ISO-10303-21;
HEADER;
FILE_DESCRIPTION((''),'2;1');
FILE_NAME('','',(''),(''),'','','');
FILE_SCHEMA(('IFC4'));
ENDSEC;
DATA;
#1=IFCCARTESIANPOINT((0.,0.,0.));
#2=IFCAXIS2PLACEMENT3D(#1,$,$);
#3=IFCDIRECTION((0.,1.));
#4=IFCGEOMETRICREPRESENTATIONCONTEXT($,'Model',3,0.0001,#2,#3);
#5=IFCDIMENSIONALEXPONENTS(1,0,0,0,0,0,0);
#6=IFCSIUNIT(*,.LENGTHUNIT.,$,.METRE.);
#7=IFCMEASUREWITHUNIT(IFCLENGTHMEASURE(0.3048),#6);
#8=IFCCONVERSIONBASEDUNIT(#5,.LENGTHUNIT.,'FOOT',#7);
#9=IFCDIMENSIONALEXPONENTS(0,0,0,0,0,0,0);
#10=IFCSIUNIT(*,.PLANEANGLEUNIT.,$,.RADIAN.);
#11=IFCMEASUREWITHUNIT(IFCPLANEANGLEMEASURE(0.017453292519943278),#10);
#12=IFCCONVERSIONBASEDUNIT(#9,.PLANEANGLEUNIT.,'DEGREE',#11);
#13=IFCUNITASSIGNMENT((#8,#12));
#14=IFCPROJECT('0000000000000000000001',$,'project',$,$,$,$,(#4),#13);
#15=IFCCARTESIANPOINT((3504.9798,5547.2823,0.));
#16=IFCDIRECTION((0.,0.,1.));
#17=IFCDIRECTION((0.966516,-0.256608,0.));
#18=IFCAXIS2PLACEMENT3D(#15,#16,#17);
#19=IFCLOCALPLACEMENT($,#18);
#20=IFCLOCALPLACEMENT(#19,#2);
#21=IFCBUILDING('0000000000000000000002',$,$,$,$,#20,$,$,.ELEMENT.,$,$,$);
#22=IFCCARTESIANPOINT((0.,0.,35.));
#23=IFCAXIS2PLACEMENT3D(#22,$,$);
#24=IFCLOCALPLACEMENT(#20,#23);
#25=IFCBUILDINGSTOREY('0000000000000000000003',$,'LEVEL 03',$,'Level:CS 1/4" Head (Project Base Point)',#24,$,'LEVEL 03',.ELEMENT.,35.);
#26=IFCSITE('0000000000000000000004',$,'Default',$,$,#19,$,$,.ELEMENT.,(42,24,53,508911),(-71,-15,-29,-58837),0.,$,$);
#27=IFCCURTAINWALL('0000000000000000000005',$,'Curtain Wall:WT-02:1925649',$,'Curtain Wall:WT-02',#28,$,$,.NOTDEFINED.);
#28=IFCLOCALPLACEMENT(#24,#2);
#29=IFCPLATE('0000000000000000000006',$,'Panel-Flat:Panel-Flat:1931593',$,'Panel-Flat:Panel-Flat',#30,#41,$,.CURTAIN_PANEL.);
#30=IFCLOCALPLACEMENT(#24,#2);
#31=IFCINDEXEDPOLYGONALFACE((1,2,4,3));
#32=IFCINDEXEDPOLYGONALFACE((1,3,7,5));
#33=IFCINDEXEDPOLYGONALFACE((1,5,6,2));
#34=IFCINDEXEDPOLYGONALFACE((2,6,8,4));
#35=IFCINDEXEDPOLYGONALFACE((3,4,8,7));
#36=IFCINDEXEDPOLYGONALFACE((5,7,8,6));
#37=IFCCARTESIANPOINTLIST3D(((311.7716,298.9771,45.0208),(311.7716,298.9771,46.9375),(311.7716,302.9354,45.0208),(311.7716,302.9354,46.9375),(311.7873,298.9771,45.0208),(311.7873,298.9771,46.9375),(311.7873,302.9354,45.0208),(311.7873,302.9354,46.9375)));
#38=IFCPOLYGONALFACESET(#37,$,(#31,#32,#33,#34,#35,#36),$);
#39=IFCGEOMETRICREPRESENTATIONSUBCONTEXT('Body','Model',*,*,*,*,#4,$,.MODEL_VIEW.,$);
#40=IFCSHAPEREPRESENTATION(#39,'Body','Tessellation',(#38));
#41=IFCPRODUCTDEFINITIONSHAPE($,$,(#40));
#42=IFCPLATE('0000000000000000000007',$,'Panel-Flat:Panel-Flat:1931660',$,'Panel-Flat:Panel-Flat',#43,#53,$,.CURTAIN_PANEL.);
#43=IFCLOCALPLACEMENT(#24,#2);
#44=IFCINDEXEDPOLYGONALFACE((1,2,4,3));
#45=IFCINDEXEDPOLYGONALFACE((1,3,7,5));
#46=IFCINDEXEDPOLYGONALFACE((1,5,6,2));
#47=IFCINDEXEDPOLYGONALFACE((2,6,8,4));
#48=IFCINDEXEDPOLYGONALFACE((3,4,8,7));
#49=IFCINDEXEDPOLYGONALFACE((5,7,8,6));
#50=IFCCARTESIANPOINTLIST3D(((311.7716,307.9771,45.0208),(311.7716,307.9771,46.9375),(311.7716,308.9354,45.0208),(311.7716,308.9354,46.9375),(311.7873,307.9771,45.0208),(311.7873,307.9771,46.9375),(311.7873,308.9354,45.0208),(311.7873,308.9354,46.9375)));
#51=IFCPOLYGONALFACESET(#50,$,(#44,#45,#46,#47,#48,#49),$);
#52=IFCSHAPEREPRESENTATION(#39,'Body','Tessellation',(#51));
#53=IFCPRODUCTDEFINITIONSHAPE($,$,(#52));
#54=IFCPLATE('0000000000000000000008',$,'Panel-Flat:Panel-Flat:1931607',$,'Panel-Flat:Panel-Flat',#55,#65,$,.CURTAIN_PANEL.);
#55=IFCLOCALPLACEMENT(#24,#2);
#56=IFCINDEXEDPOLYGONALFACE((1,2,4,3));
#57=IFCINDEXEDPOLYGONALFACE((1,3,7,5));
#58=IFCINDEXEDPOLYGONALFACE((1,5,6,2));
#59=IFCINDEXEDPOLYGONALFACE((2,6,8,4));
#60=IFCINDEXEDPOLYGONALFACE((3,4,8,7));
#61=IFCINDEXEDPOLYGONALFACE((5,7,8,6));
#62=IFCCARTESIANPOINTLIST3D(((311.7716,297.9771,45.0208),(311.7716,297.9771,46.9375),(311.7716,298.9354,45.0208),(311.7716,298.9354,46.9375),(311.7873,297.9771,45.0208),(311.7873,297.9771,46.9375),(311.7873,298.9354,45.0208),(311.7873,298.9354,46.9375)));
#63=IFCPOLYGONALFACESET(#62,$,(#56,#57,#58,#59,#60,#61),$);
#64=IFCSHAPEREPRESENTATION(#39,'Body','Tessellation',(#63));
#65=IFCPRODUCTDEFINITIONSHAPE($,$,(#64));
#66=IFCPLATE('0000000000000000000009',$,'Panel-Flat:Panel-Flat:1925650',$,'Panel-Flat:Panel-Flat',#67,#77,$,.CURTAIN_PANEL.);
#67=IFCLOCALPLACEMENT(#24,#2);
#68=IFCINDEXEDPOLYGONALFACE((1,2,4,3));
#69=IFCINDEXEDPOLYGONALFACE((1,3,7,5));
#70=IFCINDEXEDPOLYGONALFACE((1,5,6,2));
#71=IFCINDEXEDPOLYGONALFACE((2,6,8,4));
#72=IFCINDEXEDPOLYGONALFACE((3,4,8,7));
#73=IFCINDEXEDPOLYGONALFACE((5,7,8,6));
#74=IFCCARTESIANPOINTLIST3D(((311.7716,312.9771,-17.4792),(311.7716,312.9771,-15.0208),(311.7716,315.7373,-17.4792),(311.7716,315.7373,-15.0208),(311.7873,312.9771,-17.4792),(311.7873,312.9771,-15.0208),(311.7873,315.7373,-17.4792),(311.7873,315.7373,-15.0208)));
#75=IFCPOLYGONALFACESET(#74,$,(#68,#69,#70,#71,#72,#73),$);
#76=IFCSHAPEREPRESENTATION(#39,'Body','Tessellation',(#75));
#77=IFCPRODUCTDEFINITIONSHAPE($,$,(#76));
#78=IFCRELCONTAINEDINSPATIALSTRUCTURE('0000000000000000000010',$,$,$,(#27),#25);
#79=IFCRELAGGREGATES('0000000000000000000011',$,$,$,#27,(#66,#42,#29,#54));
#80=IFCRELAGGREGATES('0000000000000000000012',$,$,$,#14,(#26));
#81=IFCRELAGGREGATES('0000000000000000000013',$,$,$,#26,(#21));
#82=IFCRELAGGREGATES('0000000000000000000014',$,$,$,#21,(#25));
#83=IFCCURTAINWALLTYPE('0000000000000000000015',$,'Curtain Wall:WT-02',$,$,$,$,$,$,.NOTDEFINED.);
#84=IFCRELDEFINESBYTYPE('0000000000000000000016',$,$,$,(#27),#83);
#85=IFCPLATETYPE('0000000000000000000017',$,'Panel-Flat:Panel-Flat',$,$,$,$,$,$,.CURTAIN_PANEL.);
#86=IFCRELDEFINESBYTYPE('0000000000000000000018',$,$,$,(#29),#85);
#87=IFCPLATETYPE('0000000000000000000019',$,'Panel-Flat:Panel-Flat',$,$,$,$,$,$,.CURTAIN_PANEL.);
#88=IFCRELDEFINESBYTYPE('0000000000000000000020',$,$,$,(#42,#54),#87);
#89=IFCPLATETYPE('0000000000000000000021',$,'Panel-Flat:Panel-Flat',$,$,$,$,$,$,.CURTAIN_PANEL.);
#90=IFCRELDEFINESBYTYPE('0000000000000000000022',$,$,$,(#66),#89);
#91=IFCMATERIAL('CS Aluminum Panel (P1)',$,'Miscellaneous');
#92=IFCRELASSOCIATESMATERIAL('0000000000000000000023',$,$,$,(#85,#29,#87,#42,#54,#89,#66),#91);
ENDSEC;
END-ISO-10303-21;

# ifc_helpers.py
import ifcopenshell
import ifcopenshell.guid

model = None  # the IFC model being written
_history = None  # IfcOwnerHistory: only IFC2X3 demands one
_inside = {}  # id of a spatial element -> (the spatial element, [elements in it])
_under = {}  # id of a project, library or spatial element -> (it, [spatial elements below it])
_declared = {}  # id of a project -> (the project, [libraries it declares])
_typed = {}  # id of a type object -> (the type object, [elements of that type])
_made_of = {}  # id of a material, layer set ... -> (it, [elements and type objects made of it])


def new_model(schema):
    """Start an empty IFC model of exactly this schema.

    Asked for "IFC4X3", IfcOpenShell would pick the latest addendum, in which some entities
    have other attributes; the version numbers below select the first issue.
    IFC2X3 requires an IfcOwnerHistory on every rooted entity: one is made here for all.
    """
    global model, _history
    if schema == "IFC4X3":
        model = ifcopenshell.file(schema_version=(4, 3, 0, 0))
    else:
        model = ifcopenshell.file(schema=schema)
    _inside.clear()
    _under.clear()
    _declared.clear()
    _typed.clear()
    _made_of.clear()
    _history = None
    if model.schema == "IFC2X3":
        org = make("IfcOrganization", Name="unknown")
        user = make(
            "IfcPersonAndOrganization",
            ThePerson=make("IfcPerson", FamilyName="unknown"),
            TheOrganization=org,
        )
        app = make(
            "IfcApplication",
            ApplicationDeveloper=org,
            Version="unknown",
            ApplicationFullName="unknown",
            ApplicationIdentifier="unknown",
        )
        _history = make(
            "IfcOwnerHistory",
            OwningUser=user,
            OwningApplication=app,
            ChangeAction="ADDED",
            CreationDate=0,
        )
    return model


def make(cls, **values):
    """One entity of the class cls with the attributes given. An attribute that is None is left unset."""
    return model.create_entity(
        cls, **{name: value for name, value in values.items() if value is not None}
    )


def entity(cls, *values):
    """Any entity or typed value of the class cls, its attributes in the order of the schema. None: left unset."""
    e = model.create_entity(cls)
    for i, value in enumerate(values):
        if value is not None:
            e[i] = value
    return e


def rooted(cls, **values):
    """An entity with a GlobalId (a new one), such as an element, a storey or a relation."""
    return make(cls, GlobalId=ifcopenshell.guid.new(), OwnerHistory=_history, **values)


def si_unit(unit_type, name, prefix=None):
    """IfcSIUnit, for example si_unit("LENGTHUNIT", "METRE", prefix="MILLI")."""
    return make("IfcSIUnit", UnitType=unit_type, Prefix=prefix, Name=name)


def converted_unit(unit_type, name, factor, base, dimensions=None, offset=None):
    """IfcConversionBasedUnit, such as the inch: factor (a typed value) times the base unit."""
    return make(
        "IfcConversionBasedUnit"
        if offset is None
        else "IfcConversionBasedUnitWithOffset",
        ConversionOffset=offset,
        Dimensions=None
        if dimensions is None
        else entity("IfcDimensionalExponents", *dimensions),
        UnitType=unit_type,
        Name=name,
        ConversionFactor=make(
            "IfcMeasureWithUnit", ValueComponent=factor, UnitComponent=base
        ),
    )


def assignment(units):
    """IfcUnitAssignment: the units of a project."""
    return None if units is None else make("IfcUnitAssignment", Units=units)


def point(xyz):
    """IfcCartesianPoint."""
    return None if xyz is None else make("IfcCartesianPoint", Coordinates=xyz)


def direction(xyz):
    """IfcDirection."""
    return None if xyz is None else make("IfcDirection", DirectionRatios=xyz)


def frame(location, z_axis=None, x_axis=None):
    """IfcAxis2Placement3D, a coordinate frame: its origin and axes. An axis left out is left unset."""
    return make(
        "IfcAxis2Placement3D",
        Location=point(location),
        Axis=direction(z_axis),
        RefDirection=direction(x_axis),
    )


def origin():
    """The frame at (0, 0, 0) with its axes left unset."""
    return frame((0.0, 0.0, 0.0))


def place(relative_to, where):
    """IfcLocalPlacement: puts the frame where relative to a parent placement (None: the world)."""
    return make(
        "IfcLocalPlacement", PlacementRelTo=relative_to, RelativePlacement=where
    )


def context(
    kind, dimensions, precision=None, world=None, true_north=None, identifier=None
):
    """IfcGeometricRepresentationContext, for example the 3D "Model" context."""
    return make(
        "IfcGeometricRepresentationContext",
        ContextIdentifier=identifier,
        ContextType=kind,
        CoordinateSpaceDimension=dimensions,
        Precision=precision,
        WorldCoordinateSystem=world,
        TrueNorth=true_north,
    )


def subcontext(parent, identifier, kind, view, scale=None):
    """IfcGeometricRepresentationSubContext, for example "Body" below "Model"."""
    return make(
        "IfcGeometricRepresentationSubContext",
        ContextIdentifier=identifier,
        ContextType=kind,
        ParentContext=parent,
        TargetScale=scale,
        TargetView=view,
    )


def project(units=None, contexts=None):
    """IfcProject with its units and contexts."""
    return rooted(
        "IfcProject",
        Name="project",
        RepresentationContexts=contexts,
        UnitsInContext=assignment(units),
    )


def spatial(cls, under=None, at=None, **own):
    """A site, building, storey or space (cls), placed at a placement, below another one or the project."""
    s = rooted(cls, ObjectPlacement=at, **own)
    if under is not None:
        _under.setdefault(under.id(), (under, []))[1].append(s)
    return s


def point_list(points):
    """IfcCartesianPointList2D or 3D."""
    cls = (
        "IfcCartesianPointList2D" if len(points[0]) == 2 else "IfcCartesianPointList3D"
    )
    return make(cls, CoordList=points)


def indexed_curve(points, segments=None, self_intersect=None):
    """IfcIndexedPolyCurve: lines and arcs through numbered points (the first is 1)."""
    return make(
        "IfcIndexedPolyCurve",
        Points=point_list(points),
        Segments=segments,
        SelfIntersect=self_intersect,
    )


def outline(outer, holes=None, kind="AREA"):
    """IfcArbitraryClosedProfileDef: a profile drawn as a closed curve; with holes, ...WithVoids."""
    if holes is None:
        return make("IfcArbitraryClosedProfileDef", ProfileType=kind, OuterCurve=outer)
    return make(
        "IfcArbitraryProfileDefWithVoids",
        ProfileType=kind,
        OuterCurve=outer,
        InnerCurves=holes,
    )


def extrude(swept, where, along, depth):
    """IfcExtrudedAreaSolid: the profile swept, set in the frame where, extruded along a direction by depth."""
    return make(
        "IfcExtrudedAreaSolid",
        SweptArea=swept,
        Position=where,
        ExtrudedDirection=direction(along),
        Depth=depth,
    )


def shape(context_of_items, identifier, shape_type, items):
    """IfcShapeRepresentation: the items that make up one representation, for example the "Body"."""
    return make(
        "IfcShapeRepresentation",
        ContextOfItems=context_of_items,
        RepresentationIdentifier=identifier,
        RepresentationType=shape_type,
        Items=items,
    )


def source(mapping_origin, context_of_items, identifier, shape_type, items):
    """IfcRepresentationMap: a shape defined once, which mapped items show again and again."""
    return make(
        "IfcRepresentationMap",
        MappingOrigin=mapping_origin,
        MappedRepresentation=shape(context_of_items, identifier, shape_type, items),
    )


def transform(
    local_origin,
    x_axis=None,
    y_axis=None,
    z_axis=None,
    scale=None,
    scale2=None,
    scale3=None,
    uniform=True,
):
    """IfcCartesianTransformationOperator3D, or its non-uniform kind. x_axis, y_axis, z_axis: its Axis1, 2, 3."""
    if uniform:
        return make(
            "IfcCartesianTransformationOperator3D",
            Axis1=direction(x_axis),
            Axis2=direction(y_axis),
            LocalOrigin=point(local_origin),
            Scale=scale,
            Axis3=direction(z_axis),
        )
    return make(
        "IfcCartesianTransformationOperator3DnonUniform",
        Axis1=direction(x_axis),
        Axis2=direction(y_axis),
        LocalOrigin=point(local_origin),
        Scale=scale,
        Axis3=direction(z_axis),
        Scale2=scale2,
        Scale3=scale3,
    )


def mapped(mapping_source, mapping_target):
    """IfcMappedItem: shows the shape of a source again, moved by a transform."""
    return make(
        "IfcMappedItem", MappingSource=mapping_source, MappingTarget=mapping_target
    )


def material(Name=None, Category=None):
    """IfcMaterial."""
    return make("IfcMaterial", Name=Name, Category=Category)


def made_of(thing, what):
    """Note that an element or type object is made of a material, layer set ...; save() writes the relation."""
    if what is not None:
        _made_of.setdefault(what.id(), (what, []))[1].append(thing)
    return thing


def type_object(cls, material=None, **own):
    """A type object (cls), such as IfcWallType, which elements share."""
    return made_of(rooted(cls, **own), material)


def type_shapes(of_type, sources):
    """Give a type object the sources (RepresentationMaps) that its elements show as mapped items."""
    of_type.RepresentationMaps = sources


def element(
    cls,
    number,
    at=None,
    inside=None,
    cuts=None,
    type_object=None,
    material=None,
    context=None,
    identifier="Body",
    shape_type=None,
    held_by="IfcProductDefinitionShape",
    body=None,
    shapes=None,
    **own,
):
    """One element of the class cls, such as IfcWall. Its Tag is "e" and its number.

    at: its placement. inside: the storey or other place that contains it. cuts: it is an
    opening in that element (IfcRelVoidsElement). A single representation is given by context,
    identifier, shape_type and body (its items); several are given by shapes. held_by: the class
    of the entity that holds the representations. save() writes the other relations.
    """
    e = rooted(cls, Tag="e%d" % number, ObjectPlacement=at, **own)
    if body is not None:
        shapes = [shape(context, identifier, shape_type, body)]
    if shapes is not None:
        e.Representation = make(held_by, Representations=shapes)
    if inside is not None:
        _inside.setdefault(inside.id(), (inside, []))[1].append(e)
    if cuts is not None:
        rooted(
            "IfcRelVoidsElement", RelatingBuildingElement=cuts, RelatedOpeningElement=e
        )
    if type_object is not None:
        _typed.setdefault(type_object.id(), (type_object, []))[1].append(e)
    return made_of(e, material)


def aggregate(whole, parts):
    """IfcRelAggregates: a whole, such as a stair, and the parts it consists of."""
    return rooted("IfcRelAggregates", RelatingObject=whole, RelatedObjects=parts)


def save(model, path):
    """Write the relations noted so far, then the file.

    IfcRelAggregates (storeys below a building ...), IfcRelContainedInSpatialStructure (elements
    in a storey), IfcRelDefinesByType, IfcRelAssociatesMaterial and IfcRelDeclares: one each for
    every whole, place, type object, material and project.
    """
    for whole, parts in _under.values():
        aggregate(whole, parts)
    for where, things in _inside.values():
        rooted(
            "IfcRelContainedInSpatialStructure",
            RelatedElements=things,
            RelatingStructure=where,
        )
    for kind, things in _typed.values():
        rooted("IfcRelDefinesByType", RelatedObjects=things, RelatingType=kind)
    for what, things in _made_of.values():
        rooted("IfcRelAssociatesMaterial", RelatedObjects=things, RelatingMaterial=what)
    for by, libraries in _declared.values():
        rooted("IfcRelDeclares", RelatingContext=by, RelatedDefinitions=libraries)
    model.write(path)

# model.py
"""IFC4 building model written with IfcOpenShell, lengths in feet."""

from ifc_helpers import new_model, entity, si_unit, converted_unit, direction, frame, origin, place, context, subcontext, project, spatial, indexed_curve, outline, extrude, source, transform, mapped, material, type_object, type_shapes, element, aggregate, save


model = new_model("IFC4")

# Units and contexts
model_context = context("Model", 3, precision=0.0001, world=origin(), true_north=direction((0.0, 1.0)))
body_context = subcontext(model_context, "Body", "Model", "MODEL_VIEW")
ifc_project = project(units=[converted_unit("LENGTHUNIT", "FOOT", entity("IfcLengthMeasure", 0.3048), si_unit("LENGTHUNIT", "METRE"), dimensions=[1, 0, 0, 0, 0, 0, 0]), converted_unit("PLANEANGLEUNIT", "DEGREE", entity("IfcPlaneAngleMeasure", 0.017453292519943278), si_unit("PLANEANGLEUNIT", "RADIAN"), dimensions=[0, 0, 0, 0, 0, 0, 0])], contexts=[model_context])

# Site, building, storey
site_placement = place(None, frame((3504.9798, 5547.2823, 0.0), z_axis=(0.0, 0.0, 1.0), x_axis=(0.966516, -0.256608, 0.0)))
site = spatial("IfcSite", under=ifc_project, at=site_placement, Name="Default", CompositionType="ELEMENT", RefLatitude=(42, 24, 53, 508911), RefLongitude=(-71, -15, -29, -58837), RefElevation=0.0)
building_placement = place(site_placement, origin())
building = spatial("IfcBuilding", under=site, at=building_placement, CompositionType="ELEMENT")
storey_placement = place(building_placement, frame((0.0, 0.0, 35.0)))
storey = spatial("IfcBuildingStorey", under=building, at=storey_placement, Name="LEVEL 03", ObjectType="Level:CS 1/4\" Head (Project Base Point)", LongName="LEVEL 03", CompositionType="ELEMENT", Elevation=35.0)

# Curtain wall
curtain_wall_type = type_object("IfcCurtainWallType", Name="Curtain Wall:WT-02", PredefinedType="NOTDEFINED")
curtain_wall_1_placement = place(storey_placement, frame((0.0, 0.0, -35.0)))
curtain_wall_1 = element("IfcCurtainWall", 1, at=curtain_wall_1_placement, inside=storey, type_object=curtain_wall_type, Name="Curtain Wall:WT-02:1925649", ObjectType="Curtain Wall:WT-02", PredefinedType="NOTDEFINED")
ifc_material_1 = material(Name="CS Aluminum Panel (P1)", Category="Miscellaneous")

# Plates
plate_type_1 = type_object("IfcPlateType", Name="Panel-Flat:Panel-Flat", PredefinedType="CURTAIN_PANEL", material=ifc_material_1)
shared_shape_1 = source(origin(), body_context, "Body", "SweptSolid", [
    extrude(outline(indexed_curve([(-0.0078, -1.9792), (0.0078, -1.9792), (0.0078, 1.9792), (-0.0078, 1.9792), (-0.0078, -1.9792)], self_intersect=False)), frame((1.9792, 0.0078, 0.0), z_axis=(0.0, 0.0, 1.0), x_axis=(0.0, -1.0, 0.0)), (0.0, 0.0, 1.0), 1.9167),
])
type_shapes(plate_type_1, [shared_shape_1])
plate_1_placement = place(curtain_wall_1_placement, frame((311.7716, 302.9354, 80.0208), z_axis=(0.0, 0.0, 1.0), x_axis=(0.0, -1.0, 0.0)))
plate_1 = element("IfcPlate", 2, at=plate_1_placement, type_object=plate_type_1, material=ifc_material_1, Name="Panel-Flat:Panel-Flat:1931593", ObjectType="Panel-Flat:Panel-Flat", PredefinedType="CURTAIN_PANEL", context=body_context, shape_type="MappedRepresentation", body=[
    mapped(shared_shape_1, transform((0.0, 0.0, 0.0), scale=1.0)),
])
plate_type_2 = type_object("IfcPlateType", Name="Panel-Flat:Panel-Flat", PredefinedType="CURTAIN_PANEL", material=ifc_material_1)
shared_shape_2 = source(origin(), body_context, "Body", "SweptSolid", [
    extrude(outline(indexed_curve([(-0.0078, -0.4792), (0.0078, -0.4792), (0.0078, 0.4792), (-0.0078, 0.4792), (-0.0078, -0.4792)], self_intersect=False)), frame((0.4792, 0.0078, 0.0), z_axis=(0.0, 0.0, 1.0), x_axis=(0.0, -1.0, 0.0)), (0.0, 0.0, 1.0), 1.9167),
])
type_shapes(plate_type_2, [shared_shape_2])
plate_2_placement = place(curtain_wall_1_placement, frame((311.7716, 308.9354, 80.0208), z_axis=(0.0, 0.0, 1.0), x_axis=(0.0, -1.0, 0.0)))
plate_2 = element("IfcPlate", 3, at=plate_2_placement, type_object=plate_type_2, material=ifc_material_1, Name="Panel-Flat:Panel-Flat:1931660", ObjectType="Panel-Flat:Panel-Flat", PredefinedType="CURTAIN_PANEL", context=body_context, shape_type="MappedRepresentation", body=[
    mapped(shared_shape_2, transform((0.0, 0.0, 0.0), scale=1.0)),
])
plate_3_placement = place(curtain_wall_1_placement, frame((311.7716, 298.9354, 80.0208), z_axis=(0.0, 0.0, 1.0), x_axis=(0.0, -1.0, 0.0)))
plate_3 = element("IfcPlate", 4, at=plate_3_placement, type_object=plate_type_2, material=ifc_material_1, Name="Panel-Flat:Panel-Flat:1931607", ObjectType="Panel-Flat:Panel-Flat", PredefinedType="CURTAIN_PANEL", context=body_context, shape_type="MappedRepresentation", body=[
    mapped(shared_shape_2, transform((0.0, 0.0, 0.0), scale=1.0)),
])
plate_type_3 = type_object("IfcPlateType", Name="Panel-Flat:Panel-Flat", PredefinedType="CURTAIN_PANEL", material=ifc_material_1)
shared_shape_3 = source(origin(), body_context, "Body", "SweptSolid", [
    extrude(outline(indexed_curve([(-0.0078, -1.3801), (0.0078, -1.3801), (0.0078, 1.3801), (-0.0078, 1.3801), (-0.0078, -1.3801)], self_intersect=False)), frame((1.3801, 0.0078, 0.0), z_axis=(0.0, 0.0, 1.0), x_axis=(0.0, -1.0, 0.0)), (0.0, 0.0, 1.0), 2.4583),
])
type_shapes(plate_type_3, [shared_shape_3])
plate_4_placement = place(curtain_wall_1_placement, frame((311.7716, 315.7373, 17.5208), z_axis=(0.0, 0.0, 1.0), x_axis=(0.0, -1.0, 0.0)))
plate_4 = element("IfcPlate", 5, at=plate_4_placement, type_object=plate_type_3, material=ifc_material_1, Name="Panel-Flat:Panel-Flat:1925650", ObjectType="Panel-Flat:Panel-Flat", PredefinedType="CURTAIN_PANEL", context=body_context, shape_type="MappedRepresentation", body=[
    mapped(shared_shape_3, transform((0.0, 0.0, 0.0), scale=1.0)),
])
aggregate(curtain_wall_1, [plate_4, plate_2, plate_1, plate_3])

save(model, "model.ifc")
